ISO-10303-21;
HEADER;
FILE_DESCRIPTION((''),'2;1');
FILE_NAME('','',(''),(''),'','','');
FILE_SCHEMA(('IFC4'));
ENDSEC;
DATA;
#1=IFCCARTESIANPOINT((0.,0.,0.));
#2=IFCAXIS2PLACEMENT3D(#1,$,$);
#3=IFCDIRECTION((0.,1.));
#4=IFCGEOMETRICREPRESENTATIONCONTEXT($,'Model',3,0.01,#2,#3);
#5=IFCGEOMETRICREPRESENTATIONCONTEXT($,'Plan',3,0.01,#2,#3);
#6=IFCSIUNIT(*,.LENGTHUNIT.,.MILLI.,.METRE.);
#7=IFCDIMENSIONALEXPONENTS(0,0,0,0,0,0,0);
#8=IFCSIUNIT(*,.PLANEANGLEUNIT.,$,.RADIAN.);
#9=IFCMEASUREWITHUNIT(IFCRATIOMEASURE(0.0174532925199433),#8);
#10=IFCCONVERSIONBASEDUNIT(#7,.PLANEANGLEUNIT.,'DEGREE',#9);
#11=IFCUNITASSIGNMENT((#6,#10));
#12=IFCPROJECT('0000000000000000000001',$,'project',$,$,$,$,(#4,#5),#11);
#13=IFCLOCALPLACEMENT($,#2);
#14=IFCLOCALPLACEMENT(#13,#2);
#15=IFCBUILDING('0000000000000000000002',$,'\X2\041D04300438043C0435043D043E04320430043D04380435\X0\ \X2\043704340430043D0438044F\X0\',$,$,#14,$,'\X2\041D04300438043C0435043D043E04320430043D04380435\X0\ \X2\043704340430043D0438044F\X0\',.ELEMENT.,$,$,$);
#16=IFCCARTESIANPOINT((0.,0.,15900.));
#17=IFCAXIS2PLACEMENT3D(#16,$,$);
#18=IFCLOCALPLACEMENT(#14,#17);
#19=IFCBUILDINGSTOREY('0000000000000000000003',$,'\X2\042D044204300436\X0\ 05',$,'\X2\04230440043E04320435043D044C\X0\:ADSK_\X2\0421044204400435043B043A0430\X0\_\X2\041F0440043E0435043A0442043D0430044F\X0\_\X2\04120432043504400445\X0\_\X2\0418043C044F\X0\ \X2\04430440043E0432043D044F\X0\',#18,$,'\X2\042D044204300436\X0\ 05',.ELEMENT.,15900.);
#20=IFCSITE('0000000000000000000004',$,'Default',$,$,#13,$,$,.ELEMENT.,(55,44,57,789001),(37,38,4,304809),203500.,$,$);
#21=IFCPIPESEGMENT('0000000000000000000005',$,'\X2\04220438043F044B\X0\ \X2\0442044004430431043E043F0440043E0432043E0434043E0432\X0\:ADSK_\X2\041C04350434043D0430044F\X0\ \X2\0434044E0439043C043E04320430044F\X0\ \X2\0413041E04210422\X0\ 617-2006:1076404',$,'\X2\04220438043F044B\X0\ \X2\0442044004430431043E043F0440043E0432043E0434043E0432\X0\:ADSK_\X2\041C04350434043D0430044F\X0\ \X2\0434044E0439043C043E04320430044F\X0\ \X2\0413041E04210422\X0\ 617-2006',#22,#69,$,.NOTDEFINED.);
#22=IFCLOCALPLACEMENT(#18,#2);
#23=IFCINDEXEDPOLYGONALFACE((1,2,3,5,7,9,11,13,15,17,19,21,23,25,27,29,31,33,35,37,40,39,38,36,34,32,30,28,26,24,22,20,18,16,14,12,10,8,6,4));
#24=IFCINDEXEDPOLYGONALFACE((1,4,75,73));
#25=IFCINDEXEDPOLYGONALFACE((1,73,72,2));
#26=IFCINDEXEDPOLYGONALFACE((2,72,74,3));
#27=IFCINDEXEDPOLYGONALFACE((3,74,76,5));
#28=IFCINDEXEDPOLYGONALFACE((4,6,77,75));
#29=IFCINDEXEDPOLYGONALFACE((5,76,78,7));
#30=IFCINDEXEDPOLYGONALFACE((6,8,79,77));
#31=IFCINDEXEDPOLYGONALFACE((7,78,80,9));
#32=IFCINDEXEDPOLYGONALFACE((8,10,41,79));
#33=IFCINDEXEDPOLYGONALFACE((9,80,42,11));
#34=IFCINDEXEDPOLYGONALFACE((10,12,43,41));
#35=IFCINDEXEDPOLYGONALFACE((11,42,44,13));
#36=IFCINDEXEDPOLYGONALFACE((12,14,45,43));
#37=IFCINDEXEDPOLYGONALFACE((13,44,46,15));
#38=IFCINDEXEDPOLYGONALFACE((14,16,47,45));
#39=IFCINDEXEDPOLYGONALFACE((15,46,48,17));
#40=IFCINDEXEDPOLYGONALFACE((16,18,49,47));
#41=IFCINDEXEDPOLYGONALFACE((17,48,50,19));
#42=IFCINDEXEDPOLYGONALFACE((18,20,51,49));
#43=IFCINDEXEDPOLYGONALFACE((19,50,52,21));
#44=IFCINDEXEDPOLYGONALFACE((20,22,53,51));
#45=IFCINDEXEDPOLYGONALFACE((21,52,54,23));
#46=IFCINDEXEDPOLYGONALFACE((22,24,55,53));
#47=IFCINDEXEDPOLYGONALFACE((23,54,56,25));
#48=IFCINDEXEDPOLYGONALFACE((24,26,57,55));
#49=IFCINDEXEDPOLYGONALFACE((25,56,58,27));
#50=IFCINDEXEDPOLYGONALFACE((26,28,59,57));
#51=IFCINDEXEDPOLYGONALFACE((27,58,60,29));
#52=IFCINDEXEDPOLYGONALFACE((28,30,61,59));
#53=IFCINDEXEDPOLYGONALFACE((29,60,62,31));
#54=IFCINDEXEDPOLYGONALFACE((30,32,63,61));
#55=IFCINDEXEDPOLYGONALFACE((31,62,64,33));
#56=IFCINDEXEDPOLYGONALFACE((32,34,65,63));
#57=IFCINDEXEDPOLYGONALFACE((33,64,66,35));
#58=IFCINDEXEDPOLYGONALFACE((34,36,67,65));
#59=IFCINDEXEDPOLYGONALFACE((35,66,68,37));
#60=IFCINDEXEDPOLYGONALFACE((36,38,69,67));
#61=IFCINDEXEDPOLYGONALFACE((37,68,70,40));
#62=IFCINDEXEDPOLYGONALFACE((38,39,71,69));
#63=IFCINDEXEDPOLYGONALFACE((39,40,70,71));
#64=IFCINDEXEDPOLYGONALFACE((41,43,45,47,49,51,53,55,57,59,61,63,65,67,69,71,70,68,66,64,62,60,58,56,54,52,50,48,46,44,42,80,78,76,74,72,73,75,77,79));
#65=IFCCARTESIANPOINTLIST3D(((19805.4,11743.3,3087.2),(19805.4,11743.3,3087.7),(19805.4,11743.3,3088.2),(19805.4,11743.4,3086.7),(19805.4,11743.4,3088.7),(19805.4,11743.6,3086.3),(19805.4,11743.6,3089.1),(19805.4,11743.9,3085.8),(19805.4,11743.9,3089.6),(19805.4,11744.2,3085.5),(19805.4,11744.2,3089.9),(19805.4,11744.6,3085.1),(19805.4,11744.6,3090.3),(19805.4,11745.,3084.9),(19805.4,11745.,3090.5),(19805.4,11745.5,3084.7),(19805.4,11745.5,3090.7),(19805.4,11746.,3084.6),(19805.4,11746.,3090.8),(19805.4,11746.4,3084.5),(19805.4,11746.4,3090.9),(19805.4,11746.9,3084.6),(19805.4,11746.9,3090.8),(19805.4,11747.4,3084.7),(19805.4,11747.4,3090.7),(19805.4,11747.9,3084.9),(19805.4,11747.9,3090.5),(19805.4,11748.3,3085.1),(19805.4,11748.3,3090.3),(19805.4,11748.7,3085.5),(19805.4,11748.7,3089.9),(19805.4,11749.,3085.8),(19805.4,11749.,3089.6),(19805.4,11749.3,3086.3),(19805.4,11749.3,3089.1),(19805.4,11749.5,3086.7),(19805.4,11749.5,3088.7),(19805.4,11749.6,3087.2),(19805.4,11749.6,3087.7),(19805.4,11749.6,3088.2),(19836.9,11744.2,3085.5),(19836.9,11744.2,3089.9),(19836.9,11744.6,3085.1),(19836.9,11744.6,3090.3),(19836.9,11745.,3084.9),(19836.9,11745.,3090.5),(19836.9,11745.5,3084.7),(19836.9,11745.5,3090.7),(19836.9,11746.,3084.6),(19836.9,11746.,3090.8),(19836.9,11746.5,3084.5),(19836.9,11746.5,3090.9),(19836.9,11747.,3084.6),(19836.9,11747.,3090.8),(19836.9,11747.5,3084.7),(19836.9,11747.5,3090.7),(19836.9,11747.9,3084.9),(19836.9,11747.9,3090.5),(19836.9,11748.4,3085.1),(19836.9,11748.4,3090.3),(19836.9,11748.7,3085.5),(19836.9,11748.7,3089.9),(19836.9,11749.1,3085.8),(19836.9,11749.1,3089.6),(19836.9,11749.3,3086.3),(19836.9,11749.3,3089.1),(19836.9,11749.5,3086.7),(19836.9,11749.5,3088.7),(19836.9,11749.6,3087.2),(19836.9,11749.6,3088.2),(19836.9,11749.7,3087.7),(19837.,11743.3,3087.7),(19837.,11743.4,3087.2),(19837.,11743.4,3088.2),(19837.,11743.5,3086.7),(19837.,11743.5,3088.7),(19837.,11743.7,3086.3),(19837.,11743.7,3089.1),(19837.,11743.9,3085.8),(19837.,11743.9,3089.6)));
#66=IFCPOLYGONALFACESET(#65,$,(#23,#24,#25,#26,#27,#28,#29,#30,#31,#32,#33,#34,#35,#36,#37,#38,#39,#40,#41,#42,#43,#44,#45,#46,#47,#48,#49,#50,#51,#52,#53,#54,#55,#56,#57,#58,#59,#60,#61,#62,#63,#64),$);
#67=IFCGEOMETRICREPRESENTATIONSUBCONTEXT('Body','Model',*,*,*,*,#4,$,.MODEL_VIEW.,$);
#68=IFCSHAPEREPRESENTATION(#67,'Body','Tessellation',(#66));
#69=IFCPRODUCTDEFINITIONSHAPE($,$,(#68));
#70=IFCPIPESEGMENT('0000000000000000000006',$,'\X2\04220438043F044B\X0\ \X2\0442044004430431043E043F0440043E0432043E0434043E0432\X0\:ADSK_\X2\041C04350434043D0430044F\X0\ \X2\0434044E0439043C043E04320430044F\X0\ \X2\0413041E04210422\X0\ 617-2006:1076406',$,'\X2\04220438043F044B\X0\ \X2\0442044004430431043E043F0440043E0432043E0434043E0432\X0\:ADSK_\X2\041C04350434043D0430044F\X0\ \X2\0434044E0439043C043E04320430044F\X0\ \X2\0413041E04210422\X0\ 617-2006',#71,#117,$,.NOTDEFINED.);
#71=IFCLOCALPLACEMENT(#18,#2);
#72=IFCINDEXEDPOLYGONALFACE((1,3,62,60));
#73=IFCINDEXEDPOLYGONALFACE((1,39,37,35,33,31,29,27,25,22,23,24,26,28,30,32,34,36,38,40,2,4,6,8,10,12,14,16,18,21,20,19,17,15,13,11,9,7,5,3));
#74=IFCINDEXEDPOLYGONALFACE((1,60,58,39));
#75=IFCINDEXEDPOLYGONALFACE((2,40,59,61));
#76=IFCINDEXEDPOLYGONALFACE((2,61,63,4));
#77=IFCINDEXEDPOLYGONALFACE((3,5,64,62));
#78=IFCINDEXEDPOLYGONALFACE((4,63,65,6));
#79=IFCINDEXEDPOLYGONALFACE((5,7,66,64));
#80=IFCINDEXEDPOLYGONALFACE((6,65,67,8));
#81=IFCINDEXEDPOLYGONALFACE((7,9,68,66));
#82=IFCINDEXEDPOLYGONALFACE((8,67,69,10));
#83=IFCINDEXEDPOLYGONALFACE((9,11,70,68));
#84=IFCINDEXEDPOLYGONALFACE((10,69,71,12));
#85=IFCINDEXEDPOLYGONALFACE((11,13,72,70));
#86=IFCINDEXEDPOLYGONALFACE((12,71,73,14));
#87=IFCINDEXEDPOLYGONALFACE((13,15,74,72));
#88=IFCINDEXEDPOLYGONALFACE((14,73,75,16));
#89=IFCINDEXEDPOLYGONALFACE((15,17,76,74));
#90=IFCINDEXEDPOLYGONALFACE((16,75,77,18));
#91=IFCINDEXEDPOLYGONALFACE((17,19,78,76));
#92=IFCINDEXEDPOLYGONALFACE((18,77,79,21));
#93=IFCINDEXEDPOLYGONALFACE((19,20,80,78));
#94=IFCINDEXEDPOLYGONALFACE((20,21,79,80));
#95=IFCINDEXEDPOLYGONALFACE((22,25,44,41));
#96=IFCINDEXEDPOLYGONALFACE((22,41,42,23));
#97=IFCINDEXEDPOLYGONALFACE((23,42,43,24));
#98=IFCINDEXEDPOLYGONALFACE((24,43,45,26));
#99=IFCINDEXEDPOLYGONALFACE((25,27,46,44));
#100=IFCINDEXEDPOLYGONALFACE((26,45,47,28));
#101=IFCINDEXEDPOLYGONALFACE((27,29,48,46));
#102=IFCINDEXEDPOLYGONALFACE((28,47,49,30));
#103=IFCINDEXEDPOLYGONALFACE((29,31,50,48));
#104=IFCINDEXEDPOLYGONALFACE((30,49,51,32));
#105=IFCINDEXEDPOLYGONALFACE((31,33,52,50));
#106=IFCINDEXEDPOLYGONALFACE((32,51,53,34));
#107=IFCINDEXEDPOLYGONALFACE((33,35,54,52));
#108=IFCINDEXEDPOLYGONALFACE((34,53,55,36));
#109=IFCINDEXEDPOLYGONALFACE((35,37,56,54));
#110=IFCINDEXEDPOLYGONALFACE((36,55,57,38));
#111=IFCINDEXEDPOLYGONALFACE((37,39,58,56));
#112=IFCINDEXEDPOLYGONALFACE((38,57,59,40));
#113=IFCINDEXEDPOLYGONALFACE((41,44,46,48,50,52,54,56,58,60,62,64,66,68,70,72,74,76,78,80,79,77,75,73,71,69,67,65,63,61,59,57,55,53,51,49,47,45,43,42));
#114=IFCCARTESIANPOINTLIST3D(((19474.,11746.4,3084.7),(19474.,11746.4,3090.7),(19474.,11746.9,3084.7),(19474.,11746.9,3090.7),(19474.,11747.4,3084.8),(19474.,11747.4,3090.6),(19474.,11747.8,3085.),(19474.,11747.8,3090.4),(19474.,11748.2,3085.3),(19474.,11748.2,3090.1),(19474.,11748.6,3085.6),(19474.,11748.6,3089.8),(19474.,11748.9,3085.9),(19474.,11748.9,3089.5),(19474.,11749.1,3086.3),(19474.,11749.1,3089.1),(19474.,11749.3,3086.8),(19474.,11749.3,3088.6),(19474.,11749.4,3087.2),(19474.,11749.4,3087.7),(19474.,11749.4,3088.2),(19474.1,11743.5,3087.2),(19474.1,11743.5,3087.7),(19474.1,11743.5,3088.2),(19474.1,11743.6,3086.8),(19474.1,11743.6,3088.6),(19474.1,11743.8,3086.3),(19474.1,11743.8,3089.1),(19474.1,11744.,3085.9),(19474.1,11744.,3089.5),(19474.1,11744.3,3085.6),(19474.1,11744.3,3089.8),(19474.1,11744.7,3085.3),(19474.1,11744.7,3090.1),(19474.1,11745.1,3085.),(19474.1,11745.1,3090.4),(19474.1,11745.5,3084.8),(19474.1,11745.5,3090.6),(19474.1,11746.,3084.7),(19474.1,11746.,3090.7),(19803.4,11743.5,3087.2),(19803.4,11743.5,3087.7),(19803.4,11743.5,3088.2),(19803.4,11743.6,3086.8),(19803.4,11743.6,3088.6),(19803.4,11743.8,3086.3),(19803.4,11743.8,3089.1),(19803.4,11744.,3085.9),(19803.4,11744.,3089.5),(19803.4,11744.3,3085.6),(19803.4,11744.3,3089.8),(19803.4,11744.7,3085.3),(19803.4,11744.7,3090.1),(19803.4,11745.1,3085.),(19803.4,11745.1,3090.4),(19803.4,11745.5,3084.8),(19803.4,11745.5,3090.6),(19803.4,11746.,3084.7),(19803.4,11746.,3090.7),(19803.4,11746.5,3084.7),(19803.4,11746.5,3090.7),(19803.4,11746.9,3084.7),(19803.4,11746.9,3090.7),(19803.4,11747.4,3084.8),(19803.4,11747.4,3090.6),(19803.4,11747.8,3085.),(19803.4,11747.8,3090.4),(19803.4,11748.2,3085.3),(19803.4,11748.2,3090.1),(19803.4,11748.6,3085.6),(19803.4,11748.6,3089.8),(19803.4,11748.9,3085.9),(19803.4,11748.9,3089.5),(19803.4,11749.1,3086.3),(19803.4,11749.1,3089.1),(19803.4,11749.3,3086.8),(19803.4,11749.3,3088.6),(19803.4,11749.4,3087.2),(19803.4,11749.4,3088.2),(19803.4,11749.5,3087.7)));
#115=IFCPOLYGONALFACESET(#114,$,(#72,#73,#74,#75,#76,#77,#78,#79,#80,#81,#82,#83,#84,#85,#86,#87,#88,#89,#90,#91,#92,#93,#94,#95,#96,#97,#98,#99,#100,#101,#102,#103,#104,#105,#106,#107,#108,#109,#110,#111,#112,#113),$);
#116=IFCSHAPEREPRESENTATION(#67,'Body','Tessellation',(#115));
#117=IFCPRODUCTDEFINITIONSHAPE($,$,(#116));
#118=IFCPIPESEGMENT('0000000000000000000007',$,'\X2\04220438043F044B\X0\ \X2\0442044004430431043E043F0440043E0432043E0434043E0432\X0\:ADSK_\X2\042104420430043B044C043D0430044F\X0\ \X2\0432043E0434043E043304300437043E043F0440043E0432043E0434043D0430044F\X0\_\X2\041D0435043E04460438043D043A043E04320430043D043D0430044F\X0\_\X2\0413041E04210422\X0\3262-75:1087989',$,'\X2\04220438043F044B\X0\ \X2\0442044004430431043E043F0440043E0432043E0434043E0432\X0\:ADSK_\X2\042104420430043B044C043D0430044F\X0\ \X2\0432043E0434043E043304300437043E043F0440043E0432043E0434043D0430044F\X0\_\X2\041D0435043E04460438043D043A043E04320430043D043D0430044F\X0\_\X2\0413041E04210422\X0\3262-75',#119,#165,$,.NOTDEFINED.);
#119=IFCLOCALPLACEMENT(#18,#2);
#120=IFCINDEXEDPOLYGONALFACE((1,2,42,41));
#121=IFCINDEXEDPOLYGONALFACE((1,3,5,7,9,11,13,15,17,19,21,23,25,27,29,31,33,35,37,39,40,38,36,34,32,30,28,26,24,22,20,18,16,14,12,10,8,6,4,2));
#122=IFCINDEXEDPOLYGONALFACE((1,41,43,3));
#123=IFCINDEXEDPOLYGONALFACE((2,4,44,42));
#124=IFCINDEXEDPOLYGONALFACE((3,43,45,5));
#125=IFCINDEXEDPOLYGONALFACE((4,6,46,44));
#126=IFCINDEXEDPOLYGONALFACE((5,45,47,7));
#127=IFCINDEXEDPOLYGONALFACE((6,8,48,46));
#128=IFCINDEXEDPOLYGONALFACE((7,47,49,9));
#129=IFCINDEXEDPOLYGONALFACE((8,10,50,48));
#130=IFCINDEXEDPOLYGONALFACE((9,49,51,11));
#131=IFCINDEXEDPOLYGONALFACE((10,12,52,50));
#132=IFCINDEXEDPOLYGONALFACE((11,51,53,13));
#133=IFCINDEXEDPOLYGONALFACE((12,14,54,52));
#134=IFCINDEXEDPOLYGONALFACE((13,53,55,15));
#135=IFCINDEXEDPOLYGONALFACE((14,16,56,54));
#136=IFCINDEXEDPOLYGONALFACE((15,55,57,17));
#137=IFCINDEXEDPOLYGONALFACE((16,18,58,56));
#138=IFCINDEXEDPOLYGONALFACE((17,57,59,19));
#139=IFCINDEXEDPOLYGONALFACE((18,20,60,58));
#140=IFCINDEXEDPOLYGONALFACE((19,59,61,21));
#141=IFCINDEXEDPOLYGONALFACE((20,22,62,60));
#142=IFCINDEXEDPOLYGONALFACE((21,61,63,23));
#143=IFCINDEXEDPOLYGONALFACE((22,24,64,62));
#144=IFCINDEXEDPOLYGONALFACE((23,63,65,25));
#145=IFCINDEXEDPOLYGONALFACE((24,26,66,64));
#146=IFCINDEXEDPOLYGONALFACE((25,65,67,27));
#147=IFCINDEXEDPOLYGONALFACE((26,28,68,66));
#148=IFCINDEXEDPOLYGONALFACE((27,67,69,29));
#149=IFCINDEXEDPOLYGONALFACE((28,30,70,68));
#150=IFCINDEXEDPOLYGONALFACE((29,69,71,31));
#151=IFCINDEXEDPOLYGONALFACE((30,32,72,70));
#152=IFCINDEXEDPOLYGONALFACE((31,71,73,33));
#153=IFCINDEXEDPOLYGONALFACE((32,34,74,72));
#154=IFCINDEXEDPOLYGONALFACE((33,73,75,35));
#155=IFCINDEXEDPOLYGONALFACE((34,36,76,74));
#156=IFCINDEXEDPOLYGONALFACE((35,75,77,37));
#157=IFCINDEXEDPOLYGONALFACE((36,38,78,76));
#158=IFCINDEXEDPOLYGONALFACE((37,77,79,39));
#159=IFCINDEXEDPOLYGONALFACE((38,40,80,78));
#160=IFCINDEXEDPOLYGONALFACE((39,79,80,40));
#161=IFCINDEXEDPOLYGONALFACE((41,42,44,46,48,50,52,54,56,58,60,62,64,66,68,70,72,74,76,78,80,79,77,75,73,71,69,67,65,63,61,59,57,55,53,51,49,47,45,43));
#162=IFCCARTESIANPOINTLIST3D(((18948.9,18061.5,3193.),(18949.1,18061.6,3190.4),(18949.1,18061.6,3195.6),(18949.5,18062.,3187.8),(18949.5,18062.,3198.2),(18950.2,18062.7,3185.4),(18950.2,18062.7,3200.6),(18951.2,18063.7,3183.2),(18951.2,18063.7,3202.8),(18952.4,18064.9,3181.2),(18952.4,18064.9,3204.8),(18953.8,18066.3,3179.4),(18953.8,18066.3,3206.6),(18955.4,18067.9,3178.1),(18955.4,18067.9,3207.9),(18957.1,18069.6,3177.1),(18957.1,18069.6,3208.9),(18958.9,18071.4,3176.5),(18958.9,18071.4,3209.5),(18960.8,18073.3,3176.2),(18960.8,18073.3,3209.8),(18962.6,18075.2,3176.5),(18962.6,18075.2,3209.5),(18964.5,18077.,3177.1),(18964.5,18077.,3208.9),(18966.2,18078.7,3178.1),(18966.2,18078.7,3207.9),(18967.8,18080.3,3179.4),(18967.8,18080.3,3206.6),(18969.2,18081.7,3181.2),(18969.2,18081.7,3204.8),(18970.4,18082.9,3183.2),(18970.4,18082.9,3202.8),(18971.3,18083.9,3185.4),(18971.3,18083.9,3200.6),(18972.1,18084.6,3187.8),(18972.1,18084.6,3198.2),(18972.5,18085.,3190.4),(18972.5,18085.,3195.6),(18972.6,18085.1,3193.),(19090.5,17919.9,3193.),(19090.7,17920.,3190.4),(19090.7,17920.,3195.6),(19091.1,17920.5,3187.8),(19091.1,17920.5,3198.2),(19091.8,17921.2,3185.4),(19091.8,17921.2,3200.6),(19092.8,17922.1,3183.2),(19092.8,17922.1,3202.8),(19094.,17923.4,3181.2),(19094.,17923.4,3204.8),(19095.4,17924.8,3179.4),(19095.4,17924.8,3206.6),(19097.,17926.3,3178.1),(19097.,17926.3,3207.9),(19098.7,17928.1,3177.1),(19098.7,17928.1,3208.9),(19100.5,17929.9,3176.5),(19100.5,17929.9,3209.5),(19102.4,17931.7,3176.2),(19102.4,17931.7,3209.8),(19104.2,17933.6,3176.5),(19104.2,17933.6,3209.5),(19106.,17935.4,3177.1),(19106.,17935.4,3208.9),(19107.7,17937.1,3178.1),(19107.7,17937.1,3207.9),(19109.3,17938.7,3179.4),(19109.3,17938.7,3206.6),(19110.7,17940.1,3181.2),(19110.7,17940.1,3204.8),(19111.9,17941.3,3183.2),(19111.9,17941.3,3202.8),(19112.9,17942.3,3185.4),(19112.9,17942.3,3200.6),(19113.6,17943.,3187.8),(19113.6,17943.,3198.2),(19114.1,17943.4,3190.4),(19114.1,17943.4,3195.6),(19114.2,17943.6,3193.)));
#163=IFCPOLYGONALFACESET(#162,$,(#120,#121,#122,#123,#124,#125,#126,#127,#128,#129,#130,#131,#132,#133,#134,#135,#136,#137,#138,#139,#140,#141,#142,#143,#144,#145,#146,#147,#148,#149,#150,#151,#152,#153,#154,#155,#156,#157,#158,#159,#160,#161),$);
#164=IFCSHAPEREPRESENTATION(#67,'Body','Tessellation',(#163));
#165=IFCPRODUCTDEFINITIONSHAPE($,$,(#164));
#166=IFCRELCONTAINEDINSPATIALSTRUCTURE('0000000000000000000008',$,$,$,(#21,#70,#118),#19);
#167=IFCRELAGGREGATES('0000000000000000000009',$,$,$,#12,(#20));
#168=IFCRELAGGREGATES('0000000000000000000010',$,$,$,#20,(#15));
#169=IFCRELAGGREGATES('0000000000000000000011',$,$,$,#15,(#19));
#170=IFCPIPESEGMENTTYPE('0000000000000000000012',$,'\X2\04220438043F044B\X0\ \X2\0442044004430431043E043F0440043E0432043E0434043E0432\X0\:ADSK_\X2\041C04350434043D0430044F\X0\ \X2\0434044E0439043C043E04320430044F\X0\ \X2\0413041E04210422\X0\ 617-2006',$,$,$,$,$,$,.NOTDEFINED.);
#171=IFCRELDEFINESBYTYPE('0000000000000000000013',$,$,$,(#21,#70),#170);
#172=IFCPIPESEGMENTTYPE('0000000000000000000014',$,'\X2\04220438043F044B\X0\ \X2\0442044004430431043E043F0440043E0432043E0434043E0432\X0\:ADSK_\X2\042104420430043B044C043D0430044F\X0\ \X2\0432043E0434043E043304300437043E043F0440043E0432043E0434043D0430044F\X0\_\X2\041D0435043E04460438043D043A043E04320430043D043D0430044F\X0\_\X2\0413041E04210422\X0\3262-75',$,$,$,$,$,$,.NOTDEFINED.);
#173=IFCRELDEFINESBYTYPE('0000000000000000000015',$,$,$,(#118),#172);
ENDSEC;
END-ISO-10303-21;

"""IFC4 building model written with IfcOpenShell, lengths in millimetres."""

from ifc_helpers import new_model, entity, si_unit, converted_unit, direction, frame, origin, place, context, subcontext, project, spatial, indexed_curve, outline, extrude, type_object, element, save


model = new_model("IFC4")

# Units and contexts
model_context = context("Model", 3, precision=0.01, world=origin(), true_north=direction((0.0, 1.0)))
plan_context = context("Plan", 3, precision=0.01, world=origin(), true_north=direction((0.0, 1.0)))
body_context = subcontext(model_context, "Body", "Model", "MODEL_VIEW")
ifc_project = project(units=[si_unit("LENGTHUNIT", "METRE", prefix="MILLI"), converted_unit("PLANEANGLEUNIT", "DEGREE", entity("IfcRatioMeasure", 0.0174532925199433), si_unit("PLANEANGLEUNIT", "RADIAN"), dimensions=[0, 0, 0, 0, 0, 0, 0])], contexts=[model_context, plan_context])

# Site, building, storey
site_placement = place(None, origin())
site = spatial("IfcSite", under=ifc_project, at=site_placement, Name="Default", CompositionType="ELEMENT", RefLatitude=(55, 44, 57, 789001), RefLongitude=(37, 38, 4, 304809), RefElevation=203500.0)
building_placement = place(site_placement, origin())
building = spatial("IfcBuilding", under=site, at=building_placement, Name="Наименование здания", LongName="Наименование здания", CompositionType="ELEMENT")
storey_placement = place(building_placement, frame((0.0, 0.0, 15900.0)))
storey = spatial("IfcBuildingStorey", under=building, at=storey_placement, Name="Этаж 05", ObjectType="Уровень:ADSK_Стрелка_Проектная_Вверх_Имя уровня", LongName="Этаж 05", CompositionType="ELEMENT", Elevation=15900.0)

# Pipe segments
pipe_segment_type_1 = type_object("IfcPipeSegmentType", Name="Типы трубопроводов:ADSK_Медная дюймовая ГОСТ 617-2006", PredefinedType="NOTDEFINED")
placement = place(storey_placement, origin())
element("IfcPipeSegment", 1, at=placement, inside=storey, type_object=pipe_segment_type_1, Name="Типы трубопроводов:ADSK_Медная дюймовая ГОСТ 617-2006:1076404", ObjectType="Типы трубопроводов:ADSK_Медная дюймовая ГОСТ 617-2006", PredefinedType="NOTDEFINED", context=body_context, shape_type="SweptSolid", body=[
    extrude(outline(indexed_curve([(3.2, 0.0), (3.1, 0.5), (3.0, 1.0), (2.8, 1.4), (2.6, 1.9), (2.2, 2.2), (1.9, 2.6), (1.4, 2.8), (1.0, 3.0), (0.5, 3.1), (0.0, 3.2), (-0.5, 3.1), (-1.0, 3.0), (-1.4, 2.8), (-1.9, 2.6), (-2.2, 2.2), (-2.6, 1.9), (-2.8, 1.4), (-3.0, 1.0), (-3.1, 0.5), (-3.2, 0.0), (-3.1, -0.5), (-3.0, -1.0), (-2.8, -1.4), (-2.6, -1.9), (-2.2, -2.2), (-1.9, -2.6), (-1.4, -2.8), (-1.0, -3.0), (-0.5, -3.1), (0.0, -3.2), (0.5, -3.1), (1.0, -3.0), (1.4, -2.8), (1.9, -2.6), (2.2, -2.2), (2.6, -1.9), (2.8, -1.4), (3.0, -1.0), (3.1, -0.5), (3.2, 0.0)], self_intersect=False)), frame((19805.4, 11746.5, 3087.7), z_axis=(0.999999, 0.001229, 0.0), x_axis=(-0.001229, 0.999999, 0.0)), (0.0, 0.0, 1.0), 31.6),
])
element("IfcPipeSegment", 2, at=placement, inside=storey, type_object=pipe_segment_type_1, Name="Типы трубопроводов:ADSK_Медная дюймовая ГОСТ 617-2006:1076406", ObjectType="Типы трубопроводов:ADSK_Медная дюймовая ГОСТ 617-2006", PredefinedType="NOTDEFINED", context=body_context, shape_type="SweptSolid", body=[
    extrude(outline(indexed_curve([(3.0, 0.0), (3.0, 0.5), (2.9, 0.9), (2.7, 1.4), (2.4, 1.8), (2.1, 2.1), (1.8, 2.4), (1.4, 2.7), (0.9, 2.9), (0.5, 3.0), (0.0, 3.0), (-0.5, 3.0), (-0.9, 2.9), (-1.4, 2.7), (-1.8, 2.4), (-2.1, 2.1), (-2.4, 1.8), (-2.7, 1.4), (-2.9, 0.9), (-3.0, 0.5), (-3.0, 0.0), (-3.0, -0.5), (-2.9, -0.9), (-2.7, -1.4), (-2.4, -1.8), (-2.1, -2.1), (-1.8, -2.4), (-1.4, -2.7), (-0.9, -2.9), (-0.5, -3.0), (0.0, -3.0), (0.5, -3.0), (0.9, -2.9), (1.4, -2.7), (1.8, -2.4), (2.1, -2.1), (2.4, -1.8), (2.7, -1.4), (2.9, -0.9), (3.0, -0.5), (3.0, 0.0)], self_intersect=False)), frame((19474.0, 11746.5, 3087.7), z_axis=(1.0, 0.000015, 0.0), x_axis=(-0.000015, 1.0, 0.0)), (0.0, 0.0, 1.0), 329.3),
])
pipe_segment_type_2 = type_object("IfcPipeSegmentType", Name="Типы трубопроводов:ADSK_Стальная водогазопроводная_Неоцинкованная_ГОСТ3262-75", PredefinedType="NOTDEFINED")
element("IfcPipeSegment", 3, at=placement, inside=storey, type_object=pipe_segment_type_2, Name="Типы трубопроводов:ADSK_Стальная водогазопроводная_Неоцинкованная_ГОСТ3262-75:1087989", ObjectType="Типы трубопроводов:ADSK_Стальная водогазопроводная_Неоцинкованная_ГОСТ3262-75", PredefinedType="NOTDEFINED", context=body_context, shape_type="SweptSolid", body=[
    extrude(outline(indexed_curve([(16.7, 0.0), (16.5, 2.6), (15.9, 5.2), (14.9, 7.6), (13.6, 9.8), (11.8, 11.8), (9.8, 13.6), (7.6, 14.9), (5.2, 15.9), (2.6, 16.5), (0.0, 16.8), (-2.6, 16.5), (-5.2, 15.9), (-7.6, 14.9), (-9.8, 13.6), (-11.8, 11.8), (-13.6, 9.8), (-14.9, 7.6), (-15.9, 5.2), (-16.5, 2.6), (-16.7, 0.0), (-16.5, -2.6), (-15.9, -5.2), (-14.9, -7.6), (-13.6, -9.8), (-11.8, -11.8), (-9.8, -13.6), (-7.6, -14.9), (-5.2, -15.9), (-2.6, -16.5), (0.0, -16.8), (2.6, -16.5), (5.2, -15.9), (7.6, -14.9), (9.8, -13.6), (11.8, -11.8), (13.6, -9.8), (14.9, -7.6), (15.9, -5.2), (16.5, -2.6), (16.7, 0.0)], self_intersect=False)), frame((18960.8, 18073.3, 3193.0), z_axis=(0.707107, -0.707107, 0.0), x_axis=(0.707107, 0.707107, 0.0)), (0.0, 0.0, 1.0), 200.2),
])

save(model, "model.ifc")
